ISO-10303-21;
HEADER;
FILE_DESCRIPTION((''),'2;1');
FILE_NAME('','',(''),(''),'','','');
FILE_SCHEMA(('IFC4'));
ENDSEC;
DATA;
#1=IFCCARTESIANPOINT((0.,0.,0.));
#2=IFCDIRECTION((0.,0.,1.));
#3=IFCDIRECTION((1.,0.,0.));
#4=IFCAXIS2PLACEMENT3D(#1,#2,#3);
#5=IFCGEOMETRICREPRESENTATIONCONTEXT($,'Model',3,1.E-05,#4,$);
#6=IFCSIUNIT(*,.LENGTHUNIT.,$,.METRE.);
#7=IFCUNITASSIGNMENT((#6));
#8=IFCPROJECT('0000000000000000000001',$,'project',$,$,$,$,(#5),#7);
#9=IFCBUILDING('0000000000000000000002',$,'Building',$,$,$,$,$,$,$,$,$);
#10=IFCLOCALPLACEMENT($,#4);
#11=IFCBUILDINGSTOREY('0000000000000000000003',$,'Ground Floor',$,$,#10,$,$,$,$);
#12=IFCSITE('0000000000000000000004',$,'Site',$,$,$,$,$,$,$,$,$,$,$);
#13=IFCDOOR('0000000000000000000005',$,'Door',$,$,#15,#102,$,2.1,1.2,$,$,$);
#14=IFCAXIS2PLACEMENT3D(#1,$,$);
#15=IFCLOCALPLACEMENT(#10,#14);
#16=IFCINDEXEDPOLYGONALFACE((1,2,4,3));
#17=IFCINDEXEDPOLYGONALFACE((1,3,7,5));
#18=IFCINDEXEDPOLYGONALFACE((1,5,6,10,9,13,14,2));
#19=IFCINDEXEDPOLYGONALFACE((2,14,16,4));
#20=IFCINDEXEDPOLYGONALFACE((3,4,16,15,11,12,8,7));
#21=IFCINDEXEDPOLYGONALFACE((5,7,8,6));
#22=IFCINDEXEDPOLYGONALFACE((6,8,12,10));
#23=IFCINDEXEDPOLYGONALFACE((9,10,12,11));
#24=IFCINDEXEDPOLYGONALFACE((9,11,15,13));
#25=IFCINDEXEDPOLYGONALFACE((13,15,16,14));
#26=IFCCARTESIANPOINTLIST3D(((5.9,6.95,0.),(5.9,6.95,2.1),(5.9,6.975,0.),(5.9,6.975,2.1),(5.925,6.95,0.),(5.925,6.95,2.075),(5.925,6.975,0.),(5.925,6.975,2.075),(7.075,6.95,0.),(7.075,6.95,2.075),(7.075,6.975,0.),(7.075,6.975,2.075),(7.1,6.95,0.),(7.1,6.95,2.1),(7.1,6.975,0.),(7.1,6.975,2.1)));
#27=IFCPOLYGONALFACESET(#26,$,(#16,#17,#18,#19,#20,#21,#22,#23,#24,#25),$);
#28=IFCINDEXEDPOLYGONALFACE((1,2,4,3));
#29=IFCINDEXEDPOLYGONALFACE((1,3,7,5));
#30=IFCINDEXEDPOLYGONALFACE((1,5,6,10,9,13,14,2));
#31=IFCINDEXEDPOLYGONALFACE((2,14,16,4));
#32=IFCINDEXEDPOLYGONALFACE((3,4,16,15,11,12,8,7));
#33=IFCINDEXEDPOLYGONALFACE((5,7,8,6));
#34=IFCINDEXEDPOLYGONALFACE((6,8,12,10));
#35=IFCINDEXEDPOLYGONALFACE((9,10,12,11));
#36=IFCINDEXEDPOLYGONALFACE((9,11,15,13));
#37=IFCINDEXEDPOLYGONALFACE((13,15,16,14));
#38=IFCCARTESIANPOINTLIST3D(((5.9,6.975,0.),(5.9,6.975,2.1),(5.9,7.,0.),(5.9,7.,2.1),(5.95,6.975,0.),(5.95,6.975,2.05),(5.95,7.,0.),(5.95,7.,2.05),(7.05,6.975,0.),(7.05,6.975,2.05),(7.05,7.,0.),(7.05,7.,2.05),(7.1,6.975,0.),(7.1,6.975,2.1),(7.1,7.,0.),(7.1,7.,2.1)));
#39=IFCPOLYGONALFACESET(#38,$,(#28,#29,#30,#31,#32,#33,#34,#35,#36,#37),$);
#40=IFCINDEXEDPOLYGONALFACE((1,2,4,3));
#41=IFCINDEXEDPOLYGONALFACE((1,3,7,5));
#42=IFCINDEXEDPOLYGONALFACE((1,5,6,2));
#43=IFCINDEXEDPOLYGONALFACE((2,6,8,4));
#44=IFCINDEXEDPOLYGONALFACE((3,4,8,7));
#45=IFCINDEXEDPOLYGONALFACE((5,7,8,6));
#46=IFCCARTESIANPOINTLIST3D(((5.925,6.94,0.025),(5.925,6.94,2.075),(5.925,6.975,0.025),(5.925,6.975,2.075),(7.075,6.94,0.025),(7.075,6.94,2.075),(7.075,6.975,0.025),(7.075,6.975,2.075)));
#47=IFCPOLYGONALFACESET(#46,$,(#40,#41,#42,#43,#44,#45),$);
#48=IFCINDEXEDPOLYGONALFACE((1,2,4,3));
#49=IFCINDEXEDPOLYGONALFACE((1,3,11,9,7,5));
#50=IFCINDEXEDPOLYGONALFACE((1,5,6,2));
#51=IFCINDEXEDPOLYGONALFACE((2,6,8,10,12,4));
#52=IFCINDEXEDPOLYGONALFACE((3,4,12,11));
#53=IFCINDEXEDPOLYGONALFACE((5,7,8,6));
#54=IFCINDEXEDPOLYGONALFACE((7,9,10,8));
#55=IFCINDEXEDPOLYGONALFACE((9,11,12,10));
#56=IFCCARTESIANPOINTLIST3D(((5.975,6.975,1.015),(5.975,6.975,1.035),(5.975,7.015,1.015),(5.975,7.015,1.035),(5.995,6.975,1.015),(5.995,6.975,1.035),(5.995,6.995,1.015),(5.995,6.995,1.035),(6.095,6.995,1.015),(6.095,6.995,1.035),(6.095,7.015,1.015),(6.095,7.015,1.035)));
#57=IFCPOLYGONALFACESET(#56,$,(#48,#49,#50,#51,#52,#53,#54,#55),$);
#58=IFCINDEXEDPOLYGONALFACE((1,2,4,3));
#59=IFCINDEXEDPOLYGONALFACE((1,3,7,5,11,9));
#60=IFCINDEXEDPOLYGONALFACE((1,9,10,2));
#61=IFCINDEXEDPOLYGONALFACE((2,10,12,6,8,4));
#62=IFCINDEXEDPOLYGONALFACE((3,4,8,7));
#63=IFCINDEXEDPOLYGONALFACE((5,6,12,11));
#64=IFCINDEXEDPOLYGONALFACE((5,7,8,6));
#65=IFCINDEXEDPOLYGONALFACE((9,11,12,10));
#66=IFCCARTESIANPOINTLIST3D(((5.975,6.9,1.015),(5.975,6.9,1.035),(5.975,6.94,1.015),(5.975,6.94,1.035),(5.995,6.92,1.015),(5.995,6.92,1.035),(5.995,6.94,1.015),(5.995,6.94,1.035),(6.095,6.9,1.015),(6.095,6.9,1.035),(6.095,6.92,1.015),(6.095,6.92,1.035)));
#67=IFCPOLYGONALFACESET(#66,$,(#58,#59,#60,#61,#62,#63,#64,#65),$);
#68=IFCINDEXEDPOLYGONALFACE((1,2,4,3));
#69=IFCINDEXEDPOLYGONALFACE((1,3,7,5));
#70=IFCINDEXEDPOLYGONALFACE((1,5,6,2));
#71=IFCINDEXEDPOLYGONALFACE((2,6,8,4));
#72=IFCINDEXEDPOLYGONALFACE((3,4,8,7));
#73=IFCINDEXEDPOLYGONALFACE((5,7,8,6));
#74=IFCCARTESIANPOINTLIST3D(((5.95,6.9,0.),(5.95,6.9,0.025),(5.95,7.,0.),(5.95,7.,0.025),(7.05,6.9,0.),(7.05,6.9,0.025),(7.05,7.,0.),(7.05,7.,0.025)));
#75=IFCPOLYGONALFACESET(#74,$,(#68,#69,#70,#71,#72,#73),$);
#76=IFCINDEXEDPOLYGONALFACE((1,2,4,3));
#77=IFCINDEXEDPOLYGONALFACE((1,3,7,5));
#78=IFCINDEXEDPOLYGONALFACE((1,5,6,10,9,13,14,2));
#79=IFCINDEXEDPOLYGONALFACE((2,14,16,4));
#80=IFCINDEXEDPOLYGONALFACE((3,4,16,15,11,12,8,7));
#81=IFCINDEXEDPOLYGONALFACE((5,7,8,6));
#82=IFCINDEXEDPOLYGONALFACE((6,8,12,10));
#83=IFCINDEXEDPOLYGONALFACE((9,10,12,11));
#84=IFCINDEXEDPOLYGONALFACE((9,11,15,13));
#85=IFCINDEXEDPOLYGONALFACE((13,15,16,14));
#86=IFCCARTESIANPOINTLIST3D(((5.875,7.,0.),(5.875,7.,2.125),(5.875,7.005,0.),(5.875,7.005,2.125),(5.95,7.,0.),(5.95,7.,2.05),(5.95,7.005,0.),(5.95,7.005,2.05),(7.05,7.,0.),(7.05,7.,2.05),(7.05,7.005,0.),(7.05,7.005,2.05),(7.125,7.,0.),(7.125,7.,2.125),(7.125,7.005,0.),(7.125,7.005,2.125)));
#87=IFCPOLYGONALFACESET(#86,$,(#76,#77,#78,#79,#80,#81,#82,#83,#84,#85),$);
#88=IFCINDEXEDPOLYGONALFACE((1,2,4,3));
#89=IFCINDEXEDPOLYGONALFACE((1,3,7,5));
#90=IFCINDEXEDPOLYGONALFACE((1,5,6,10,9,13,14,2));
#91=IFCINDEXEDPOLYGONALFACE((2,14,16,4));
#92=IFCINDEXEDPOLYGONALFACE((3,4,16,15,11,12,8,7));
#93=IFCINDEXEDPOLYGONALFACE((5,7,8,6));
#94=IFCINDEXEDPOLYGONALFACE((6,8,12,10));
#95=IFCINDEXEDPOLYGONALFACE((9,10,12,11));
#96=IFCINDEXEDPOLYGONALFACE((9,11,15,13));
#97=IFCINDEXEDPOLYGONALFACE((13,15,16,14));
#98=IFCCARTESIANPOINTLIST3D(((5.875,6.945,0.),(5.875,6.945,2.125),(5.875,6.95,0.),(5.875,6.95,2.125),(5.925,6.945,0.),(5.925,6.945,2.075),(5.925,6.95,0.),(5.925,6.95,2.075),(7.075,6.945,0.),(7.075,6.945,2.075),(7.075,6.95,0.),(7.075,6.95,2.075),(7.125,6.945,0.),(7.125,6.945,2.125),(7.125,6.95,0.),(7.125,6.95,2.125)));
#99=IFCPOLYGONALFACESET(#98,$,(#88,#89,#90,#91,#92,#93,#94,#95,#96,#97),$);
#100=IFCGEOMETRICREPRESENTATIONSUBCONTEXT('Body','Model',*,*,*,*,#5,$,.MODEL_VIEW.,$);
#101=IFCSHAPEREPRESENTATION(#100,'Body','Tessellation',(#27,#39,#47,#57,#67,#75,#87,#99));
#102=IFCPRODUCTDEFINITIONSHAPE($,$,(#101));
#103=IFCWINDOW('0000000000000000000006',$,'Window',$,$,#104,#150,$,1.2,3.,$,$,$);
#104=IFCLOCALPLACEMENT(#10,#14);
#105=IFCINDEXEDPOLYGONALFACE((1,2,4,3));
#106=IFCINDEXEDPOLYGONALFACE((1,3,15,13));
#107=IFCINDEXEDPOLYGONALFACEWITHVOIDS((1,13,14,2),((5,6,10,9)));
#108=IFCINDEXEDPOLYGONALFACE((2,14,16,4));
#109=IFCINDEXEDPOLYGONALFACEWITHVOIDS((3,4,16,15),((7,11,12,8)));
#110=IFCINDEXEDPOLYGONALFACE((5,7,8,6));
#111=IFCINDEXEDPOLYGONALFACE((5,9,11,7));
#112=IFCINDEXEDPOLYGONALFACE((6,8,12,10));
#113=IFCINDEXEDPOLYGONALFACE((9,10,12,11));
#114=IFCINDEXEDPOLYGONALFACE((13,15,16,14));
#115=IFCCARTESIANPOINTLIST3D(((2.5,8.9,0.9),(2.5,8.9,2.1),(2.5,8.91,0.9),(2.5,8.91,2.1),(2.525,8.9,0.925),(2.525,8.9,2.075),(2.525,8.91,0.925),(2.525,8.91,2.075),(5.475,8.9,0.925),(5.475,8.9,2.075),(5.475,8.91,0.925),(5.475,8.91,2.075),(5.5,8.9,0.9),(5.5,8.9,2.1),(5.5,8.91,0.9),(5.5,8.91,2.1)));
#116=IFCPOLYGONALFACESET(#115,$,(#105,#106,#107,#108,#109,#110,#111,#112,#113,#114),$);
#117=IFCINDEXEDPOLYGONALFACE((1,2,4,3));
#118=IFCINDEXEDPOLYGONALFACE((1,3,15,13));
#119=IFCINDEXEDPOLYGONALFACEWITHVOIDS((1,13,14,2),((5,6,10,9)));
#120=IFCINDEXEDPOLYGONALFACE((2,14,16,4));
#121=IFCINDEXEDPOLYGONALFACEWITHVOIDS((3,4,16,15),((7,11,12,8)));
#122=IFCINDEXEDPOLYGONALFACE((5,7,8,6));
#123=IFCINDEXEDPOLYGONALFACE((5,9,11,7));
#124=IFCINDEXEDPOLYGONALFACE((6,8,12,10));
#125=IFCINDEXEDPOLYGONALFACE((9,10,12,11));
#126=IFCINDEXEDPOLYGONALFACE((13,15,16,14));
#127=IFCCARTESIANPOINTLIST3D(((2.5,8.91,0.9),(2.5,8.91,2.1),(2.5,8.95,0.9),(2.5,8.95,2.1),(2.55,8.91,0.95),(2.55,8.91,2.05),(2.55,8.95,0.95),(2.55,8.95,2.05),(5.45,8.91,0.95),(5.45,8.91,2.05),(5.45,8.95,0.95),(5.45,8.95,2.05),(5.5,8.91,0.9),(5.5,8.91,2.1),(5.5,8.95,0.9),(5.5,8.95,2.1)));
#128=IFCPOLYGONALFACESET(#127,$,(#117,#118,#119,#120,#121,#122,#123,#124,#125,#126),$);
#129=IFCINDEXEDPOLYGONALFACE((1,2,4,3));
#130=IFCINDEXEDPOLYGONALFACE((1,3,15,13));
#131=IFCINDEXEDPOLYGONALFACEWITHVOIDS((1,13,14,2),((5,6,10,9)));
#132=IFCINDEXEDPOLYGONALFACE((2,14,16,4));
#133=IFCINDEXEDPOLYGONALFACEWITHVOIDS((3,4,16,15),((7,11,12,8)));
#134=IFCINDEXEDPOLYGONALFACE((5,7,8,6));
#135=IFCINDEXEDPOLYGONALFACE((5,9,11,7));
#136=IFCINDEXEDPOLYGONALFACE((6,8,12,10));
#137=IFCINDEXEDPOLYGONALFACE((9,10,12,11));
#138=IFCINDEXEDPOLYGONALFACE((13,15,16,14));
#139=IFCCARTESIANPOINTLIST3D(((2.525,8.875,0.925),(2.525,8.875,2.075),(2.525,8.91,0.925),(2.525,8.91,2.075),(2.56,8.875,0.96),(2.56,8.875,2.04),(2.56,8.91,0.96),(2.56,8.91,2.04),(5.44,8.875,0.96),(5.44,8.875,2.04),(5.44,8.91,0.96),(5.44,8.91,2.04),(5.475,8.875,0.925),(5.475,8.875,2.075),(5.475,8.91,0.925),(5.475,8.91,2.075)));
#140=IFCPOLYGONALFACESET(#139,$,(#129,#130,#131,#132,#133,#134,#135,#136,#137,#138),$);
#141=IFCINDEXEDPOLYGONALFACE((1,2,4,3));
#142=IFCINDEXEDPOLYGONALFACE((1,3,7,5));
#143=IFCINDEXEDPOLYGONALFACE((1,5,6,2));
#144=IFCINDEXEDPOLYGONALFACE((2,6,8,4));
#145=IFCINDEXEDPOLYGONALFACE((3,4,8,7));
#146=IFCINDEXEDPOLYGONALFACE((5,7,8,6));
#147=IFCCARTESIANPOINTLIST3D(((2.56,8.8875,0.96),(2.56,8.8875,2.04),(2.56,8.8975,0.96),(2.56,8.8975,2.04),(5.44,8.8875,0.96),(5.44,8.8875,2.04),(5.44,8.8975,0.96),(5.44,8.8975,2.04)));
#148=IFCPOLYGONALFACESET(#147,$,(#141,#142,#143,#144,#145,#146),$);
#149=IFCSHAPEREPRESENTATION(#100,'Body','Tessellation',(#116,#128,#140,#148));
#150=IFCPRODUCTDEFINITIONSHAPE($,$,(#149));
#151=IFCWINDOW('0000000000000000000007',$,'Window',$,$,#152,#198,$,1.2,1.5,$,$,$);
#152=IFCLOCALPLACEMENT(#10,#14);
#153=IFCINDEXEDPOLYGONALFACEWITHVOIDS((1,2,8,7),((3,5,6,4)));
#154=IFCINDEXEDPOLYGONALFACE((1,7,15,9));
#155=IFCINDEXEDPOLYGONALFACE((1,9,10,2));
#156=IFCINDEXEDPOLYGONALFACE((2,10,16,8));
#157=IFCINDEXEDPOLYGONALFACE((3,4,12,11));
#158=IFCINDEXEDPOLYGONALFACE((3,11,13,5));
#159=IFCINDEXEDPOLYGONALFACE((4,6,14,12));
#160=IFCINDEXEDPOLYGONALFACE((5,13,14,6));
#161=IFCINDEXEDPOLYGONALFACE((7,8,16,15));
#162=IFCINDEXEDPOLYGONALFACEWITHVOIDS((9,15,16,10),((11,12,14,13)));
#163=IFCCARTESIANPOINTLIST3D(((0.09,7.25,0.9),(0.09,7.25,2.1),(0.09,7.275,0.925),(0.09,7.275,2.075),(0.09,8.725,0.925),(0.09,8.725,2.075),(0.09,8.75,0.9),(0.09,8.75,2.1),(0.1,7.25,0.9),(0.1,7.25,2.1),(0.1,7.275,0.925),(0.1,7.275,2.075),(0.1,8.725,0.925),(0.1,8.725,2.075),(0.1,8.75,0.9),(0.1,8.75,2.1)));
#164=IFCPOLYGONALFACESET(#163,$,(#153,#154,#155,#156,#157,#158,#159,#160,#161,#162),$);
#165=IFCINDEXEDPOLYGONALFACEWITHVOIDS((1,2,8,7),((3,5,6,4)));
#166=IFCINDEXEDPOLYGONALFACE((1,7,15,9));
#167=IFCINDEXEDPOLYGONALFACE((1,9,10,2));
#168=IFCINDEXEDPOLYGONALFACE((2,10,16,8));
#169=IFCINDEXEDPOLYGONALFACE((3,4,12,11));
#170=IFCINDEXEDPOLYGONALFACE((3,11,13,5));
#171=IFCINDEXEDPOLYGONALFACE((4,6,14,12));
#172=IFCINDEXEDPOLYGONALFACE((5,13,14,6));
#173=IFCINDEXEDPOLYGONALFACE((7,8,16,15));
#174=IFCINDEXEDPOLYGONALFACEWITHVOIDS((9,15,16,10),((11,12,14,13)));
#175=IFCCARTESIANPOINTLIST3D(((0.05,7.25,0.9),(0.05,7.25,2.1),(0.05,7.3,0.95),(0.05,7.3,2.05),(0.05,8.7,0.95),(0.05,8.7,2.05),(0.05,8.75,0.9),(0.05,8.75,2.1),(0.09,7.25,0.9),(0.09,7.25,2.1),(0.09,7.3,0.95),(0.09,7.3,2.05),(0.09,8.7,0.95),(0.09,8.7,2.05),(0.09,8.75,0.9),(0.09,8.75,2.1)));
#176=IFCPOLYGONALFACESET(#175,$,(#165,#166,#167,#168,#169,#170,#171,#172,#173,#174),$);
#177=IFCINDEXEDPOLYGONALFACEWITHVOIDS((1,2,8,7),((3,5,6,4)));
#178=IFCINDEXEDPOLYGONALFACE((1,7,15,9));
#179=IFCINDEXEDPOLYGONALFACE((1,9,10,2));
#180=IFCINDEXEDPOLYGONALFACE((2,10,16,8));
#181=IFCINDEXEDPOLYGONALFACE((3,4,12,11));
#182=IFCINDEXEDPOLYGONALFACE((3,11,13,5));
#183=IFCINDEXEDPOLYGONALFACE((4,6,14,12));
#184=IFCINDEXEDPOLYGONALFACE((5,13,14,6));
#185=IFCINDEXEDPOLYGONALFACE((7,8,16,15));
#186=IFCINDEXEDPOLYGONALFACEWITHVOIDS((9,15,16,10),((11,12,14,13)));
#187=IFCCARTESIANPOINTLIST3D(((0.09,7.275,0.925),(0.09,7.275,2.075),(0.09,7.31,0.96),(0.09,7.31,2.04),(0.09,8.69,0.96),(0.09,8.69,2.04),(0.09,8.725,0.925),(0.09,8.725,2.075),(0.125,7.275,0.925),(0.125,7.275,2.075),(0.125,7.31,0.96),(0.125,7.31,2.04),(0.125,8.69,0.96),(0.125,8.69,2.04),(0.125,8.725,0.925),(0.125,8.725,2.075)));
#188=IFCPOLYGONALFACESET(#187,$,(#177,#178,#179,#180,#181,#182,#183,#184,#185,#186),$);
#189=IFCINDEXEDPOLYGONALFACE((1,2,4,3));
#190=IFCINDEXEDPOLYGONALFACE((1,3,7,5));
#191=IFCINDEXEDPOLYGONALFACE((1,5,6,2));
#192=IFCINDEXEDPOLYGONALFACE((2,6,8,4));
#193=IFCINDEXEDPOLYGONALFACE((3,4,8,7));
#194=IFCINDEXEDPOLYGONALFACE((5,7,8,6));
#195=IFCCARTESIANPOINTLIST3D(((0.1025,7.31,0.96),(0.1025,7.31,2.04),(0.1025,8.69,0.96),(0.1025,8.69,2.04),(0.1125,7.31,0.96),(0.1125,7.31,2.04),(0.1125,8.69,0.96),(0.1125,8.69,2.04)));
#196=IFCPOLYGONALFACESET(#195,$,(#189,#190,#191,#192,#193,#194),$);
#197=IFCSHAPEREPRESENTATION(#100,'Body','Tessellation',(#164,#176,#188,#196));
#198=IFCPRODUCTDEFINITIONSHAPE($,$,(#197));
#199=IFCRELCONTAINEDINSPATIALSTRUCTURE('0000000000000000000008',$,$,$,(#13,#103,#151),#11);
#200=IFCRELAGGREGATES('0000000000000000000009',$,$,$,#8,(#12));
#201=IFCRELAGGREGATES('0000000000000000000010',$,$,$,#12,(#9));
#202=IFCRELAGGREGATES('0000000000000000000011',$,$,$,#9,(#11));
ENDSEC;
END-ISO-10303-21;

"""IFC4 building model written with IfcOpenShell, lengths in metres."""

from ifc_helpers import new_model, si_unit, frame, origin_with_axes, place, context, subcontext, project, spatial, line, indexed_curve, outline, extrude, element, save


model = new_model("IFC4")

# Units and contexts
model_context = context("Model", 3, precision=1e-05, world=origin_with_axes())
body_context = subcontext(model_context, "Body", "Model", "MODEL_VIEW")
ifc_project = project(units=[si_unit("LENGTHUNIT", "METRE")], contexts=[model_context])

# Site, building, storey
site = spatial("IfcSite", under=ifc_project, Name="Site")
building = spatial("IfcBuilding", under=site, Name="Building")
storey_placement = place(None, origin_with_axes())
storey = spatial("IfcBuildingStorey", under=building, at=storey_placement, Name="Ground Floor")

# Door
door_1_placement = place(storey_placement, frame((7.1, 7.0, 0.0), z_axis=(0.0, 0.0, 1.0), x_axis=(-1.0, 0.0, 0.0)))
element("IfcDoor", 1, at=door_1_placement, inside=storey, Name="Door", OverallHeight=2.1, OverallWidth=1.2, context=body_context, shape_type="SweptSolid", body=[
    extrude(outline(indexed_curve([(0.0, 0.0), (0.0, 2.1), (1.2, 2.1), (1.2, 0.0), (1.175, 0.0), (1.175, 2.075), (0.025, 2.075), (0.025, 0.0)], segments=[line(1, 2, 3, 4, 5, 6, 7, 8, 1)])), frame((0.0, 0.025, 0.0), z_axis=(0.0, -1.0, 0.0), x_axis=(1.0, 0.0, 0.0)), (0.0, 0.0, -1.0), 0.025),
    extrude(outline(indexed_curve([(0.0, 0.0), (0.0, 2.1), (1.2, 2.1), (1.2, 0.0), (1.15, 0.0), (1.15, 2.05), (0.05, 2.05), (0.05, 0.0)], segments=[line(1, 2, 3, 4, 5, 6, 7, 8, 1)])), frame((0.0, 0.0, 0.0), z_axis=(0.0, -1.0, 0.0), x_axis=(1.0, 0.0, 0.0)), (0.0, 0.0, -1.0), 0.025),
    extrude(outline(indexed_curve([(0.0, 0.0), (1.15, 0.0), (1.15, 0.035), (0.0, 0.035)], segments=[line(1, 2, 3, 4, 1)])), frame((0.025, 0.025, 0.025), z_axis=(0.0, 0.0, 1.0), x_axis=(1.0, 0.0, 0.0)), (0.0, 0.0, 1.0), 2.05),
    extrude(outline(indexed_curve([(0.0, 0.0), (0.0, -0.04), (-0.12, -0.04), (-0.12, -0.02), (-0.02, -0.02), (-0.02, 0.0)], segments=[line(1, 2, 3, 4, 5, 6, 1)])), frame((1.125, 0.025, 1.015), z_axis=(0.0, 0.0, 1.0), x_axis=(1.0, 0.0, 0.0)), (0.0, 0.0, 1.0), 0.02),
    extrude(outline(indexed_curve([(0.0, 0.0), (0.0, 0.04), (-0.12, 0.04), (-0.12, 0.02), (-0.02, 0.02), (-0.02, 0.0)], segments=[line(1, 2, 3, 4, 5, 6, 1)])), frame((1.125, 0.06, 1.015), z_axis=(0.0, 0.0, 1.0), x_axis=(1.0, 0.0, 0.0)), (0.0, 0.0, 1.0), 0.02),
    extrude(outline(indexed_curve([(0.0, 0.0), (1.1, 0.0), (1.1, 0.1), (0.0, 0.1)], segments=[line(1, 2, 3, 4, 1)])), frame((0.05, 0.0, 0.0), z_axis=(0.0, 0.0, 1.0), x_axis=(1.0, 0.0, 0.0)), (0.0, 0.0, 1.0), 0.025),
    extrude(outline(indexed_curve([(0.0, 0.0), (0.0, 2.125), (1.25, 2.125), (1.25, 0.0), (1.175, 0.0), (1.175, 2.05), (0.075, 2.05), (0.075, 0.0)], segments=[line(1, 2, 3, 4, 5, 6, 7, 8, 1)])), frame((-0.025, -0.005, 0.0), z_axis=(0.0, -1.0, 0.0), x_axis=(1.0, 0.0, 0.0)), (0.0, 0.0, -1.0), 0.005),
    extrude(outline(indexed_curve([(0.0, 0.0), (0.0, 2.125), (1.25, 2.125), (1.25, 0.0), (1.2, 0.0), (1.2, 2.075), (0.05, 2.075), (0.05, 0.0)], segments=[line(1, 2, 3, 4, 5, 6, 7, 8, 1)])), frame((-0.025, 0.05, 0.0), z_axis=(0.0, -1.0, 0.0), x_axis=(1.0, 0.0, 0.0)), (0.0, 0.0, -1.0), 0.005),
])

# Windows
window_placement = place(storey_placement, frame((5.5, 9.0, 0.9), z_axis=(0.0, 0.0, 1.0), x_axis=(-1.0, 0.0, 0.0)))
element("IfcWindow", 2, at=window_placement, inside=storey, Name="Window", OverallHeight=1.2, OverallWidth=3.0, context=body_context, shape_type="SweptSolid", body=[
    extrude(outline(indexed_curve([(0.0, 0.0), (3.0, 0.0), (3.0, 1.2), (0.0, 1.2)], segments=[line(1, 2, 3, 4, 1)]), holes=[indexed_curve([(0.025, 0.025), (2.975, 0.025), (2.975, 1.175), (0.025, 1.175)], segments=[line(1, 2, 3, 4, 1)])]), frame((0.0, 0.09, 0.0), z_axis=(0.0, -1.0, 0.0), x_axis=(1.0, 0.0, 0.0)), (0.0, 0.0, -1.0), 0.01),
    extrude(outline(indexed_curve([(0.0, 0.0), (3.0, 0.0), (3.0, 1.2), (0.0, 1.2)], segments=[line(1, 2, 3, 4, 1)]), holes=[indexed_curve([(0.05, 0.05), (2.95, 0.05), (2.95, 1.15), (0.05, 1.15)], segments=[line(1, 2, 3, 4, 1)])]), frame((0.0, 0.05, 0.0), z_axis=(0.0, -1.0, 0.0), x_axis=(1.0, 0.0, 0.0)), (0.0, 0.0, -1.0), 0.04),
    extrude(outline(indexed_curve([(0.0, 0.0), (2.95, 0.0), (2.95, 1.15), (0.0, 1.15)], segments=[line(1, 2, 3, 4, 1)]), holes=[indexed_curve([(0.035, 0.035), (2.915, 0.035), (2.915, 1.115), (0.035, 1.115)], segments=[line(1, 2, 3, 4, 1)])]), frame((0.025, 0.09, 0.025), z_axis=(0.0, -1.0, 0.0), x_axis=(1.0, 0.0, 0.0)), (0.0, 0.0, -1.0), 0.035),
    extrude(outline(indexed_curve([(0.035, 0.035), (2.915, 0.035), (2.915, 1.115), (0.035, 1.115)], segments=[line(1, 2, 3, 4, 1)])), frame((0.025, 0.1025, 0.025), z_axis=(0.0, -1.0, 0.0), x_axis=(1.0, 0.0, 0.0)), (0.0, 0.0, -1.0), 0.01),
])
for number, where, z_axis, x_axis, name in (
    (3, (0.0, 8.75, 0.9), (0.0, 0.0, 1.0), (0.0, -1.0, 0.0), "Window"),
):
    element("IfcWindow", number, at=place(storey_placement, frame(where, z_axis=z_axis, x_axis=x_axis)), inside=storey, Name=name, OverallHeight=1.2, OverallWidth=1.5, context=body_context, shape_type="SweptSolid", body=[
        extrude(outline(indexed_curve([(0.0, 0.0), (1.5, 0.0), (1.5, 1.2), (0.0, 1.2)], segments=[line(1, 2, 3, 4, 1)]), holes=[indexed_curve([(0.025, 0.025), (1.475, 0.025), (1.475, 1.175), (0.025, 1.175)], segments=[line(1, 2, 3, 4, 1)])]), frame((0.0, 0.09, 0.0), z_axis=(0.0, -1.0, 0.0), x_axis=(1.0, 0.0, 0.0)), (0.0, 0.0, -1.0), 0.01),
        extrude(outline(indexed_curve([(0.0, 0.0), (1.5, 0.0), (1.5, 1.2), (0.0, 1.2)], segments=[line(1, 2, 3, 4, 1)]), holes=[indexed_curve([(0.05, 0.05), (1.45, 0.05), (1.45, 1.15), (0.05, 1.15)], segments=[line(1, 2, 3, 4, 1)])]), frame((0.0, 0.05, 0.0), z_axis=(0.0, -1.0, 0.0), x_axis=(1.0, 0.0, 0.0)), (0.0, 0.0, -1.0), 0.04),
        extrude(outline(indexed_curve([(0.0, 0.0), (1.45, 0.0), (1.45, 1.15), (0.0, 1.15)], segments=[line(1, 2, 3, 4, 1)]), holes=[indexed_curve([(0.035, 0.035), (1.415, 0.035), (1.415, 1.115), (0.035, 1.115)], segments=[line(1, 2, 3, 4, 1)])]), frame((0.025, 0.09, 0.025), z_axis=(0.0, -1.0, 0.0), x_axis=(1.0, 0.0, 0.0)), (0.0, 0.0, -1.0), 0.035),
        extrude(outline(indexed_curve([(0.035, 0.035), (1.415, 0.035), (1.415, 1.115), (0.035, 1.115)], segments=[line(1, 2, 3, 4, 1)])), frame((0.025, 0.1025, 0.025), z_axis=(0.0, -1.0, 0.0), x_axis=(1.0, 0.0, 0.0)), (0.0, 0.0, -1.0), 0.01),
    ])

save(model, "model.ifc")
